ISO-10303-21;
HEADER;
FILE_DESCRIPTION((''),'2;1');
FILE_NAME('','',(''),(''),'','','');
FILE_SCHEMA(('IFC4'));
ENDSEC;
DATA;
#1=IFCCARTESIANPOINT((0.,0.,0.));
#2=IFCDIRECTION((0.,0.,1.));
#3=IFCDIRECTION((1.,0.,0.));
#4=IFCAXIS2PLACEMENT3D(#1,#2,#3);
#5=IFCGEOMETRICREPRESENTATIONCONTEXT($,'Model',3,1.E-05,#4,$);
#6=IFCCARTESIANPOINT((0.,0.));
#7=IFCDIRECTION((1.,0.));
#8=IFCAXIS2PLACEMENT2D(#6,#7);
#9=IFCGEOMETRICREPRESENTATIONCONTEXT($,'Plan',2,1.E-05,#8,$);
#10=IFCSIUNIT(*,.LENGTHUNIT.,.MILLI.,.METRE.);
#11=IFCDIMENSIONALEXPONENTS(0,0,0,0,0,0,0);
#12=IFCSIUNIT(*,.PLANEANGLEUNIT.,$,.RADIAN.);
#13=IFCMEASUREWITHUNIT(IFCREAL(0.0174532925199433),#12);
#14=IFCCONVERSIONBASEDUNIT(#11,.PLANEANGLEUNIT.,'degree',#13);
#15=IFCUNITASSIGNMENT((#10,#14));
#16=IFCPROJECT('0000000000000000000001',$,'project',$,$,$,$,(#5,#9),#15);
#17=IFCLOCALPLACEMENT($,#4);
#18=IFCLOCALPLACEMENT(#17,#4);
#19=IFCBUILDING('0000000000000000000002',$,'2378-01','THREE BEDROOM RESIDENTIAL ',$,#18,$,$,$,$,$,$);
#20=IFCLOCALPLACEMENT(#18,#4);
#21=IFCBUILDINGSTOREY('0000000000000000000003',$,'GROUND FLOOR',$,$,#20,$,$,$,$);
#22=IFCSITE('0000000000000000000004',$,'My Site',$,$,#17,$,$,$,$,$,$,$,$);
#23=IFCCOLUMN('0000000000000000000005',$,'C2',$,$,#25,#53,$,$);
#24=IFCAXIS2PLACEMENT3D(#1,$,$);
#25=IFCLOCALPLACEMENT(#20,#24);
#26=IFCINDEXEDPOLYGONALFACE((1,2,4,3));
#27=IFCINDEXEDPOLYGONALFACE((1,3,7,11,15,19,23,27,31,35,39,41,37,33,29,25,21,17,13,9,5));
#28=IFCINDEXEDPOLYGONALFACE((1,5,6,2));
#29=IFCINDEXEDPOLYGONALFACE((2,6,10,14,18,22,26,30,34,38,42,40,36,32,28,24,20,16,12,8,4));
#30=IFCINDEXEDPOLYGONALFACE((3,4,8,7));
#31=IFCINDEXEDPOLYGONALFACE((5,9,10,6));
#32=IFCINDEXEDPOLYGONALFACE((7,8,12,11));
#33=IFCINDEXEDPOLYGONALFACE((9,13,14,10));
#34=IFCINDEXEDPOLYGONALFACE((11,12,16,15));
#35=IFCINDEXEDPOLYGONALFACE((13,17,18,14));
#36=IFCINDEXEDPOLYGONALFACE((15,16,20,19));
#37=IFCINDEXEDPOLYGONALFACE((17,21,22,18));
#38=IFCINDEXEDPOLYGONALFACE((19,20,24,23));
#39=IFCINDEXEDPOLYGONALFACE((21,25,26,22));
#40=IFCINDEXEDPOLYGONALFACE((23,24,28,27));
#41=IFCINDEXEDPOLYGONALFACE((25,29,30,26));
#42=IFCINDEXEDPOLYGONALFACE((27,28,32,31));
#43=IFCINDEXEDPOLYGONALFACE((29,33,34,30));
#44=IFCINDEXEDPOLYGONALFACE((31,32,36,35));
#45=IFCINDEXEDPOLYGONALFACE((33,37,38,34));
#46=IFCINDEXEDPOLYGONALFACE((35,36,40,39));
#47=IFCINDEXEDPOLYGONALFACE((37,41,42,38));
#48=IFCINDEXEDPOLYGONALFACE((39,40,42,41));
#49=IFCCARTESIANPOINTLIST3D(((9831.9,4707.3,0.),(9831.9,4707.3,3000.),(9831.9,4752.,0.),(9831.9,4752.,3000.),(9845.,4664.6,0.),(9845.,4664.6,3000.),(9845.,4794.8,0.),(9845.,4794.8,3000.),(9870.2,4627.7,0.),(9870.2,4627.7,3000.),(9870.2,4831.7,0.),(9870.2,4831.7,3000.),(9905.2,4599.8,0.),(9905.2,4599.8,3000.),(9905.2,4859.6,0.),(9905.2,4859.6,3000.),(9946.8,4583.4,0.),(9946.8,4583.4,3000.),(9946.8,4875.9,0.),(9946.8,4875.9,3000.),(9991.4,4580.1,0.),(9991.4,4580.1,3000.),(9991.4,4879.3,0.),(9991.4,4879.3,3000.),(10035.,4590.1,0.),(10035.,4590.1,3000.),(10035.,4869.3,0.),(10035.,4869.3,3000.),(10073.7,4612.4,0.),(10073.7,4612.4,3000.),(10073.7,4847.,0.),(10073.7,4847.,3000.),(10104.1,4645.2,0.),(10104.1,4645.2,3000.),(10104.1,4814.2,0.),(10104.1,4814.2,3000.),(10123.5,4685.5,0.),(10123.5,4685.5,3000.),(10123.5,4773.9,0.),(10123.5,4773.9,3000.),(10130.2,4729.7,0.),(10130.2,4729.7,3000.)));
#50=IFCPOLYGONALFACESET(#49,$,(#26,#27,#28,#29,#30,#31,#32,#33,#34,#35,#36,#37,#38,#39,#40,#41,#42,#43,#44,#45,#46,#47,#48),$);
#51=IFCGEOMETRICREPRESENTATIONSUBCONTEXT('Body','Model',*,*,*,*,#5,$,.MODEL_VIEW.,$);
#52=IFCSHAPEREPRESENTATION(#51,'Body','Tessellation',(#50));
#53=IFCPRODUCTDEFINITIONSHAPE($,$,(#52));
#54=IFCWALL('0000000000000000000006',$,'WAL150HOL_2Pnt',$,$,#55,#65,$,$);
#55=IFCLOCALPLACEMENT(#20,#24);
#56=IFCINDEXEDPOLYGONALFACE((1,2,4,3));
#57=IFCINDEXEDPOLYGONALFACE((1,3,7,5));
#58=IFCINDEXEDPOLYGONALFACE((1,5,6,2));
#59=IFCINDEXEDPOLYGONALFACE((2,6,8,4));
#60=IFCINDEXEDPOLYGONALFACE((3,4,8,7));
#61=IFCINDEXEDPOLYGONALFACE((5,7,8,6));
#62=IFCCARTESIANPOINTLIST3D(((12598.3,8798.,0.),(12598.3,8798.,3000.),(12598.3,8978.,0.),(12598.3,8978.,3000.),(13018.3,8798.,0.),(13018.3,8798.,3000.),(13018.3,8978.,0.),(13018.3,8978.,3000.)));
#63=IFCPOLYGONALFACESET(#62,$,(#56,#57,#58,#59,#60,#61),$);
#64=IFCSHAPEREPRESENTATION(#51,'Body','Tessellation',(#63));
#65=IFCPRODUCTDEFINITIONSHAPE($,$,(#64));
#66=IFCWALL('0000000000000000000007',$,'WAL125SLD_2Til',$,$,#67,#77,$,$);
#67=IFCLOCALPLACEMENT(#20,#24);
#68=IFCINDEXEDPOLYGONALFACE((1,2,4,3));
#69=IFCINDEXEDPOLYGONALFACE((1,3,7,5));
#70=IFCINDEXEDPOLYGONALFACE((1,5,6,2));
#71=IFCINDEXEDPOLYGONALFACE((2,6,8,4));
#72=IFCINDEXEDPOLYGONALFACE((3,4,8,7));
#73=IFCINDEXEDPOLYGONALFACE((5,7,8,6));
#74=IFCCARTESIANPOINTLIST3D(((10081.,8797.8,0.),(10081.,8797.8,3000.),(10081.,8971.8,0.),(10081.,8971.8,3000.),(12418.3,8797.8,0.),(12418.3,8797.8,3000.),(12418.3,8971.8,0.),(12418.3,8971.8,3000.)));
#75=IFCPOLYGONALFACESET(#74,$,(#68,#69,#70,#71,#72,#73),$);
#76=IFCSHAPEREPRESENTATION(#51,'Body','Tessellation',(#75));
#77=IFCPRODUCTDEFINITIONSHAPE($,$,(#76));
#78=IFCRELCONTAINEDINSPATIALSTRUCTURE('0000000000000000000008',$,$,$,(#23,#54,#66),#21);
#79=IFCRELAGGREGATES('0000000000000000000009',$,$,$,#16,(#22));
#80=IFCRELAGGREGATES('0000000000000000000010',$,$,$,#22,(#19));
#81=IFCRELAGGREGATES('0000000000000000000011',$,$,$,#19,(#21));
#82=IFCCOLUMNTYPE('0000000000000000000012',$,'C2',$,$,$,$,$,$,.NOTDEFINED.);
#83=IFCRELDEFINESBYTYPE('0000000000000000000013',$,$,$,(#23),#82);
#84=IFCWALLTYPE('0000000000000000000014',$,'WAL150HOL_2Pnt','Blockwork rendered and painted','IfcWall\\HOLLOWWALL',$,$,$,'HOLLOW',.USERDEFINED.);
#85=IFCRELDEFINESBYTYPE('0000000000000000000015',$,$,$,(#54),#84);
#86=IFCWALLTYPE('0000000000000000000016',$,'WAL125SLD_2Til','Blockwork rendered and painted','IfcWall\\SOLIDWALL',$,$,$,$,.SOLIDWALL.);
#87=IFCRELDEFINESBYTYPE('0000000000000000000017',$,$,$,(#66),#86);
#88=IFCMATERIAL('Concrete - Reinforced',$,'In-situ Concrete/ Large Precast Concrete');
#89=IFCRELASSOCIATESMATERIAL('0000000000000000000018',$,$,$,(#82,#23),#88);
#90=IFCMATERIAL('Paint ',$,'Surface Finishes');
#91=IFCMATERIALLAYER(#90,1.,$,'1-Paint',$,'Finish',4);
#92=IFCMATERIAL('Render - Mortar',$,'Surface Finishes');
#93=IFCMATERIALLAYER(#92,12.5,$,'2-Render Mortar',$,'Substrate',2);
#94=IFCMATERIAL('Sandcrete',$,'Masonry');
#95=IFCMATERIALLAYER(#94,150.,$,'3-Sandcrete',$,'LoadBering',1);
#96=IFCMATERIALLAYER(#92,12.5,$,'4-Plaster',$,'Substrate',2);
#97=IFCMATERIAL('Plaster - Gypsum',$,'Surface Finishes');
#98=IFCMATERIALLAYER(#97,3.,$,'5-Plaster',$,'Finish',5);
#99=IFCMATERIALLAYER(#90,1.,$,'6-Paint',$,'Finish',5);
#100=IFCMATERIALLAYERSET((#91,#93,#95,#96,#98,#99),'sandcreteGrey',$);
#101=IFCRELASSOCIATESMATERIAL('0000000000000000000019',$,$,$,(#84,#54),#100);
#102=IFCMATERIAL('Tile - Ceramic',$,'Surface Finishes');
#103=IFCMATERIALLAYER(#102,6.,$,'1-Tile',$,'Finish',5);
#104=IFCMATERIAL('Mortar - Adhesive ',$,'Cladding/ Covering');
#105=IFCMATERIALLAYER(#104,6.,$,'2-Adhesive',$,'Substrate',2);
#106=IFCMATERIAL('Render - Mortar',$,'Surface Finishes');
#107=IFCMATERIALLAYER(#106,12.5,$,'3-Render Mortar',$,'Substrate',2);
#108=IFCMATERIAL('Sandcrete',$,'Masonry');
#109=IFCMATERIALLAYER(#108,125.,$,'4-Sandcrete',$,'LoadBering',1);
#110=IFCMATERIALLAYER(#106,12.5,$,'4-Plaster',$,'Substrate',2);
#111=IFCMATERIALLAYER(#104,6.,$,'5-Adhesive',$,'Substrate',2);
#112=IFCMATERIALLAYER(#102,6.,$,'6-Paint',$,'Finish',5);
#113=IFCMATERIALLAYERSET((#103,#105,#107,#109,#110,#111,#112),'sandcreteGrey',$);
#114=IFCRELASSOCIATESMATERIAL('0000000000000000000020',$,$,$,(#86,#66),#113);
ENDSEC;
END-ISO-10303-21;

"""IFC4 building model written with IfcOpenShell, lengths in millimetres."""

from ifc_helpers import new_model, entity, si_unit, converted_unit, frame, origin_with_axes, origin_2d_with_axis, place, context, subcontext, project, spatial, indexed_curve, circle, outline, extrude, material, layer, layer_set, layer_usage, material_profile, profile_set, profile_usage, type_object, element, save


model = new_model("IFC4")

# Units and contexts
model_context = context("Model", 3, precision=1e-05, world=origin_with_axes())
plan_context = context("Plan", 2, precision=1e-05, world=origin_2d_with_axis())
body_context_1 = subcontext(model_context, "Body", "Model", "MODEL_VIEW")
ifc_project = project(units=[si_unit("LENGTHUNIT", "METRE", prefix="MILLI"), converted_unit("PLANEANGLEUNIT", "degree", entity("IfcReal", 0.0174532925199433), si_unit("PLANEANGLEUNIT", "RADIAN"), dimensions=[0, 0, 0, 0, 0, 0, 0])], contexts=[model_context, plan_context])

# Site, building, storey
site_placement = place(None, origin_with_axes())
site = spatial("IfcSite", under=ifc_project, at=site_placement, Name="My Site")
building_placement = place(site_placement, origin_with_axes())
building = spatial("IfcBuilding", under=site, at=building_placement, Name="2378-01", Description="THREE BEDROOM RESIDENTIAL ")
storey_placement = place(building_placement, origin_with_axes())
storey = spatial("IfcBuildingStorey", under=building, at=storey_placement, Name="GROUND FLOOR")

# Column
ifc_material_1 = material(Name="Concrete - Reinforced", Category="In-situ Concrete/ Large Precast Concrete")
ifc_material_profile = material_profile(ifc_material_1, circle(Radius=150.0), Name="150mm  Radius", Category="LoadBearing", Priority=1)
ifc_profile_set = profile_set([ifc_material_profile], Name="concreteColumn")
ifc_profile_usage = profile_usage(ifc_profile_set)
column_type = type_object("IfcColumnType", Name="C2", PredefinedType="NOTDEFINED", material=ifc_profile_set)
column_placement = place(storey_placement, frame((9980.2, 4729.7, 0.0), z_axis=(0.0, 0.0, 1.0), x_axis=(1.0, 0.0, 0.0)))
element("IfcColumn", 1, at=column_placement, inside=storey, type_object=column_type, material=ifc_profile_usage, Name="C2", context=body_context_1, shape_type="SweptSolid", body=[
    extrude(circle(Radius=150.0), origin_with_axes(), (0.0, 0.0, 1.0), 3000.0),
])

# Shared definitions
ifc_material_2 = material(Name="Paint ", Category="Surface Finishes")
ifc_layer_1 = layer(ifc_material_2, 1.0, Name="1-Paint", Category="Finish", Priority=4)
ifc_material_3 = material(Name="Render - Mortar", Category="Surface Finishes")
ifc_layer_2 = layer(ifc_material_3, 12.5, Name="2-Render Mortar", Category="Substrate", Priority=2)
ifc_material_4 = material(Name="Sandcrete", Category="Masonry")
ifc_layer_3 = layer(ifc_material_4, 150.0, Name="3-Sandcrete", Category="LoadBering", Priority=1)
ifc_layer_4 = layer(ifc_material_3, 12.5, Name="4-Plaster", Category="Substrate", Priority=2)
ifc_material_5 = material(Name="Plaster - Gypsum", Category="Surface Finishes")
ifc_layer_5 = layer(ifc_material_5, 3.0, Name="5-Plaster", Category="Finish", Priority=5)
ifc_layer_6 = layer(ifc_material_2, 1.0, Name="6-Paint", Category="Finish", Priority=5)
ifc_layer_set_1 = layer_set([ifc_layer_1, ifc_layer_2, ifc_layer_3, ifc_layer_4, ifc_layer_5, ifc_layer_6], Name="sandcreteGrey")
wall_type_1 = type_object("IfcWallType", Name="WAL150HOL_2Pnt", Description="Blockwork rendered and painted", ApplicableOccurrence="IfcWall\\HOLLOWWALL", ElementType="HOLLOW", PredefinedType="USERDEFINED", material=ifc_layer_set_1)

# Walls
ifc_layer_usage_1 = layer_usage(ifc_layer_set_1, "AXIS2", "POSITIVE", 0.0)
wall_1_placement = place(storey_placement, frame((13018.3, 8978.0, 0.0), z_axis=(0.0, 0.0, 1.0), x_axis=(-1.0, 0.000001, 0.0)))
element("IfcWall", 2, at=wall_1_placement, inside=storey, type_object=wall_type_1, material=ifc_layer_usage_1, Name="WAL150HOL_2Pnt", context=body_context_1, shape_type="SweptSolid", body=[
    extrude(outline(indexed_curve([(0.0, 0.0), (0.0, 180.0), (420.0, 180.0), (420.0, 0.0), (0.0, 0.0)], self_intersect=False)), origin_with_axes(), (0.0, 0.0, 1.0), 3000.0),
])
ifc_material_6 = material(Name="Tile - Ceramic", Category="Surface Finishes")
ifc_layer_7 = layer(ifc_material_6, 6.0, Name="1-Tile", Category="Finish", Priority=5)
ifc_material_7 = material(Name="Mortar - Adhesive ", Category="Cladding/ Covering")
ifc_layer_8 = layer(ifc_material_7, 6.0, Name="2-Adhesive", Category="Substrate", Priority=2)
ifc_material_8 = material(Name="Render - Mortar", Category="Surface Finishes")
ifc_layer_9 = layer(ifc_material_8, 12.5, Name="3-Render Mortar", Category="Substrate", Priority=2)
ifc_material_9 = material(Name="Sandcrete", Category="Masonry")
ifc_layer_10 = layer(ifc_material_9, 125.0, Name="4-Sandcrete", Category="LoadBering", Priority=1)
ifc_layer_11 = layer(ifc_material_8, 12.5, Name="4-Plaster", Category="Substrate", Priority=2)
ifc_layer_12 = layer(ifc_material_7, 6.0, Name="5-Adhesive", Category="Substrate", Priority=2)
ifc_layer_13 = layer(ifc_material_6, 6.0, Name="6-Paint", Category="Finish", Priority=5)
ifc_layer_set_2 = layer_set([ifc_layer_7, ifc_layer_8, ifc_layer_9, ifc_layer_10, ifc_layer_11, ifc_layer_12, ifc_layer_13], Name="sandcreteGrey")
ifc_layer_usage_2 = layer_usage(ifc_layer_set_2, "AXIS2", "POSITIVE", 0.0)
wall_type_2 = type_object("IfcWallType", Name="WAL125SLD_2Til", Description="Blockwork rendered and painted", ApplicableOccurrence="IfcWall\\SOLIDWALL", PredefinedType="SOLIDWALL", material=ifc_layer_set_2)
wall_2_placement = place(storey_placement, frame((10081.0, 8797.8, 0.0), z_axis=(0.0, 0.0, 1.0), x_axis=(1.0, -0.000001, 0.0)))
element("IfcWall", 3, at=wall_2_placement, inside=storey, type_object=wall_type_2, material=ifc_layer_usage_2, Name="WAL125SLD_2Til", context=body_context_1, shape_type="SweptSolid", body=[
    extrude(outline(indexed_curve([(0.0, 0.0), (0.0, 174.0), (2337.3, 174.0), (2337.3, 0.0), (0.0, 0.0)], self_intersect=False)), origin_with_axes(), (0.0, 0.0, 1.0), 3000.0),
])

save(model, "model.ifc")
